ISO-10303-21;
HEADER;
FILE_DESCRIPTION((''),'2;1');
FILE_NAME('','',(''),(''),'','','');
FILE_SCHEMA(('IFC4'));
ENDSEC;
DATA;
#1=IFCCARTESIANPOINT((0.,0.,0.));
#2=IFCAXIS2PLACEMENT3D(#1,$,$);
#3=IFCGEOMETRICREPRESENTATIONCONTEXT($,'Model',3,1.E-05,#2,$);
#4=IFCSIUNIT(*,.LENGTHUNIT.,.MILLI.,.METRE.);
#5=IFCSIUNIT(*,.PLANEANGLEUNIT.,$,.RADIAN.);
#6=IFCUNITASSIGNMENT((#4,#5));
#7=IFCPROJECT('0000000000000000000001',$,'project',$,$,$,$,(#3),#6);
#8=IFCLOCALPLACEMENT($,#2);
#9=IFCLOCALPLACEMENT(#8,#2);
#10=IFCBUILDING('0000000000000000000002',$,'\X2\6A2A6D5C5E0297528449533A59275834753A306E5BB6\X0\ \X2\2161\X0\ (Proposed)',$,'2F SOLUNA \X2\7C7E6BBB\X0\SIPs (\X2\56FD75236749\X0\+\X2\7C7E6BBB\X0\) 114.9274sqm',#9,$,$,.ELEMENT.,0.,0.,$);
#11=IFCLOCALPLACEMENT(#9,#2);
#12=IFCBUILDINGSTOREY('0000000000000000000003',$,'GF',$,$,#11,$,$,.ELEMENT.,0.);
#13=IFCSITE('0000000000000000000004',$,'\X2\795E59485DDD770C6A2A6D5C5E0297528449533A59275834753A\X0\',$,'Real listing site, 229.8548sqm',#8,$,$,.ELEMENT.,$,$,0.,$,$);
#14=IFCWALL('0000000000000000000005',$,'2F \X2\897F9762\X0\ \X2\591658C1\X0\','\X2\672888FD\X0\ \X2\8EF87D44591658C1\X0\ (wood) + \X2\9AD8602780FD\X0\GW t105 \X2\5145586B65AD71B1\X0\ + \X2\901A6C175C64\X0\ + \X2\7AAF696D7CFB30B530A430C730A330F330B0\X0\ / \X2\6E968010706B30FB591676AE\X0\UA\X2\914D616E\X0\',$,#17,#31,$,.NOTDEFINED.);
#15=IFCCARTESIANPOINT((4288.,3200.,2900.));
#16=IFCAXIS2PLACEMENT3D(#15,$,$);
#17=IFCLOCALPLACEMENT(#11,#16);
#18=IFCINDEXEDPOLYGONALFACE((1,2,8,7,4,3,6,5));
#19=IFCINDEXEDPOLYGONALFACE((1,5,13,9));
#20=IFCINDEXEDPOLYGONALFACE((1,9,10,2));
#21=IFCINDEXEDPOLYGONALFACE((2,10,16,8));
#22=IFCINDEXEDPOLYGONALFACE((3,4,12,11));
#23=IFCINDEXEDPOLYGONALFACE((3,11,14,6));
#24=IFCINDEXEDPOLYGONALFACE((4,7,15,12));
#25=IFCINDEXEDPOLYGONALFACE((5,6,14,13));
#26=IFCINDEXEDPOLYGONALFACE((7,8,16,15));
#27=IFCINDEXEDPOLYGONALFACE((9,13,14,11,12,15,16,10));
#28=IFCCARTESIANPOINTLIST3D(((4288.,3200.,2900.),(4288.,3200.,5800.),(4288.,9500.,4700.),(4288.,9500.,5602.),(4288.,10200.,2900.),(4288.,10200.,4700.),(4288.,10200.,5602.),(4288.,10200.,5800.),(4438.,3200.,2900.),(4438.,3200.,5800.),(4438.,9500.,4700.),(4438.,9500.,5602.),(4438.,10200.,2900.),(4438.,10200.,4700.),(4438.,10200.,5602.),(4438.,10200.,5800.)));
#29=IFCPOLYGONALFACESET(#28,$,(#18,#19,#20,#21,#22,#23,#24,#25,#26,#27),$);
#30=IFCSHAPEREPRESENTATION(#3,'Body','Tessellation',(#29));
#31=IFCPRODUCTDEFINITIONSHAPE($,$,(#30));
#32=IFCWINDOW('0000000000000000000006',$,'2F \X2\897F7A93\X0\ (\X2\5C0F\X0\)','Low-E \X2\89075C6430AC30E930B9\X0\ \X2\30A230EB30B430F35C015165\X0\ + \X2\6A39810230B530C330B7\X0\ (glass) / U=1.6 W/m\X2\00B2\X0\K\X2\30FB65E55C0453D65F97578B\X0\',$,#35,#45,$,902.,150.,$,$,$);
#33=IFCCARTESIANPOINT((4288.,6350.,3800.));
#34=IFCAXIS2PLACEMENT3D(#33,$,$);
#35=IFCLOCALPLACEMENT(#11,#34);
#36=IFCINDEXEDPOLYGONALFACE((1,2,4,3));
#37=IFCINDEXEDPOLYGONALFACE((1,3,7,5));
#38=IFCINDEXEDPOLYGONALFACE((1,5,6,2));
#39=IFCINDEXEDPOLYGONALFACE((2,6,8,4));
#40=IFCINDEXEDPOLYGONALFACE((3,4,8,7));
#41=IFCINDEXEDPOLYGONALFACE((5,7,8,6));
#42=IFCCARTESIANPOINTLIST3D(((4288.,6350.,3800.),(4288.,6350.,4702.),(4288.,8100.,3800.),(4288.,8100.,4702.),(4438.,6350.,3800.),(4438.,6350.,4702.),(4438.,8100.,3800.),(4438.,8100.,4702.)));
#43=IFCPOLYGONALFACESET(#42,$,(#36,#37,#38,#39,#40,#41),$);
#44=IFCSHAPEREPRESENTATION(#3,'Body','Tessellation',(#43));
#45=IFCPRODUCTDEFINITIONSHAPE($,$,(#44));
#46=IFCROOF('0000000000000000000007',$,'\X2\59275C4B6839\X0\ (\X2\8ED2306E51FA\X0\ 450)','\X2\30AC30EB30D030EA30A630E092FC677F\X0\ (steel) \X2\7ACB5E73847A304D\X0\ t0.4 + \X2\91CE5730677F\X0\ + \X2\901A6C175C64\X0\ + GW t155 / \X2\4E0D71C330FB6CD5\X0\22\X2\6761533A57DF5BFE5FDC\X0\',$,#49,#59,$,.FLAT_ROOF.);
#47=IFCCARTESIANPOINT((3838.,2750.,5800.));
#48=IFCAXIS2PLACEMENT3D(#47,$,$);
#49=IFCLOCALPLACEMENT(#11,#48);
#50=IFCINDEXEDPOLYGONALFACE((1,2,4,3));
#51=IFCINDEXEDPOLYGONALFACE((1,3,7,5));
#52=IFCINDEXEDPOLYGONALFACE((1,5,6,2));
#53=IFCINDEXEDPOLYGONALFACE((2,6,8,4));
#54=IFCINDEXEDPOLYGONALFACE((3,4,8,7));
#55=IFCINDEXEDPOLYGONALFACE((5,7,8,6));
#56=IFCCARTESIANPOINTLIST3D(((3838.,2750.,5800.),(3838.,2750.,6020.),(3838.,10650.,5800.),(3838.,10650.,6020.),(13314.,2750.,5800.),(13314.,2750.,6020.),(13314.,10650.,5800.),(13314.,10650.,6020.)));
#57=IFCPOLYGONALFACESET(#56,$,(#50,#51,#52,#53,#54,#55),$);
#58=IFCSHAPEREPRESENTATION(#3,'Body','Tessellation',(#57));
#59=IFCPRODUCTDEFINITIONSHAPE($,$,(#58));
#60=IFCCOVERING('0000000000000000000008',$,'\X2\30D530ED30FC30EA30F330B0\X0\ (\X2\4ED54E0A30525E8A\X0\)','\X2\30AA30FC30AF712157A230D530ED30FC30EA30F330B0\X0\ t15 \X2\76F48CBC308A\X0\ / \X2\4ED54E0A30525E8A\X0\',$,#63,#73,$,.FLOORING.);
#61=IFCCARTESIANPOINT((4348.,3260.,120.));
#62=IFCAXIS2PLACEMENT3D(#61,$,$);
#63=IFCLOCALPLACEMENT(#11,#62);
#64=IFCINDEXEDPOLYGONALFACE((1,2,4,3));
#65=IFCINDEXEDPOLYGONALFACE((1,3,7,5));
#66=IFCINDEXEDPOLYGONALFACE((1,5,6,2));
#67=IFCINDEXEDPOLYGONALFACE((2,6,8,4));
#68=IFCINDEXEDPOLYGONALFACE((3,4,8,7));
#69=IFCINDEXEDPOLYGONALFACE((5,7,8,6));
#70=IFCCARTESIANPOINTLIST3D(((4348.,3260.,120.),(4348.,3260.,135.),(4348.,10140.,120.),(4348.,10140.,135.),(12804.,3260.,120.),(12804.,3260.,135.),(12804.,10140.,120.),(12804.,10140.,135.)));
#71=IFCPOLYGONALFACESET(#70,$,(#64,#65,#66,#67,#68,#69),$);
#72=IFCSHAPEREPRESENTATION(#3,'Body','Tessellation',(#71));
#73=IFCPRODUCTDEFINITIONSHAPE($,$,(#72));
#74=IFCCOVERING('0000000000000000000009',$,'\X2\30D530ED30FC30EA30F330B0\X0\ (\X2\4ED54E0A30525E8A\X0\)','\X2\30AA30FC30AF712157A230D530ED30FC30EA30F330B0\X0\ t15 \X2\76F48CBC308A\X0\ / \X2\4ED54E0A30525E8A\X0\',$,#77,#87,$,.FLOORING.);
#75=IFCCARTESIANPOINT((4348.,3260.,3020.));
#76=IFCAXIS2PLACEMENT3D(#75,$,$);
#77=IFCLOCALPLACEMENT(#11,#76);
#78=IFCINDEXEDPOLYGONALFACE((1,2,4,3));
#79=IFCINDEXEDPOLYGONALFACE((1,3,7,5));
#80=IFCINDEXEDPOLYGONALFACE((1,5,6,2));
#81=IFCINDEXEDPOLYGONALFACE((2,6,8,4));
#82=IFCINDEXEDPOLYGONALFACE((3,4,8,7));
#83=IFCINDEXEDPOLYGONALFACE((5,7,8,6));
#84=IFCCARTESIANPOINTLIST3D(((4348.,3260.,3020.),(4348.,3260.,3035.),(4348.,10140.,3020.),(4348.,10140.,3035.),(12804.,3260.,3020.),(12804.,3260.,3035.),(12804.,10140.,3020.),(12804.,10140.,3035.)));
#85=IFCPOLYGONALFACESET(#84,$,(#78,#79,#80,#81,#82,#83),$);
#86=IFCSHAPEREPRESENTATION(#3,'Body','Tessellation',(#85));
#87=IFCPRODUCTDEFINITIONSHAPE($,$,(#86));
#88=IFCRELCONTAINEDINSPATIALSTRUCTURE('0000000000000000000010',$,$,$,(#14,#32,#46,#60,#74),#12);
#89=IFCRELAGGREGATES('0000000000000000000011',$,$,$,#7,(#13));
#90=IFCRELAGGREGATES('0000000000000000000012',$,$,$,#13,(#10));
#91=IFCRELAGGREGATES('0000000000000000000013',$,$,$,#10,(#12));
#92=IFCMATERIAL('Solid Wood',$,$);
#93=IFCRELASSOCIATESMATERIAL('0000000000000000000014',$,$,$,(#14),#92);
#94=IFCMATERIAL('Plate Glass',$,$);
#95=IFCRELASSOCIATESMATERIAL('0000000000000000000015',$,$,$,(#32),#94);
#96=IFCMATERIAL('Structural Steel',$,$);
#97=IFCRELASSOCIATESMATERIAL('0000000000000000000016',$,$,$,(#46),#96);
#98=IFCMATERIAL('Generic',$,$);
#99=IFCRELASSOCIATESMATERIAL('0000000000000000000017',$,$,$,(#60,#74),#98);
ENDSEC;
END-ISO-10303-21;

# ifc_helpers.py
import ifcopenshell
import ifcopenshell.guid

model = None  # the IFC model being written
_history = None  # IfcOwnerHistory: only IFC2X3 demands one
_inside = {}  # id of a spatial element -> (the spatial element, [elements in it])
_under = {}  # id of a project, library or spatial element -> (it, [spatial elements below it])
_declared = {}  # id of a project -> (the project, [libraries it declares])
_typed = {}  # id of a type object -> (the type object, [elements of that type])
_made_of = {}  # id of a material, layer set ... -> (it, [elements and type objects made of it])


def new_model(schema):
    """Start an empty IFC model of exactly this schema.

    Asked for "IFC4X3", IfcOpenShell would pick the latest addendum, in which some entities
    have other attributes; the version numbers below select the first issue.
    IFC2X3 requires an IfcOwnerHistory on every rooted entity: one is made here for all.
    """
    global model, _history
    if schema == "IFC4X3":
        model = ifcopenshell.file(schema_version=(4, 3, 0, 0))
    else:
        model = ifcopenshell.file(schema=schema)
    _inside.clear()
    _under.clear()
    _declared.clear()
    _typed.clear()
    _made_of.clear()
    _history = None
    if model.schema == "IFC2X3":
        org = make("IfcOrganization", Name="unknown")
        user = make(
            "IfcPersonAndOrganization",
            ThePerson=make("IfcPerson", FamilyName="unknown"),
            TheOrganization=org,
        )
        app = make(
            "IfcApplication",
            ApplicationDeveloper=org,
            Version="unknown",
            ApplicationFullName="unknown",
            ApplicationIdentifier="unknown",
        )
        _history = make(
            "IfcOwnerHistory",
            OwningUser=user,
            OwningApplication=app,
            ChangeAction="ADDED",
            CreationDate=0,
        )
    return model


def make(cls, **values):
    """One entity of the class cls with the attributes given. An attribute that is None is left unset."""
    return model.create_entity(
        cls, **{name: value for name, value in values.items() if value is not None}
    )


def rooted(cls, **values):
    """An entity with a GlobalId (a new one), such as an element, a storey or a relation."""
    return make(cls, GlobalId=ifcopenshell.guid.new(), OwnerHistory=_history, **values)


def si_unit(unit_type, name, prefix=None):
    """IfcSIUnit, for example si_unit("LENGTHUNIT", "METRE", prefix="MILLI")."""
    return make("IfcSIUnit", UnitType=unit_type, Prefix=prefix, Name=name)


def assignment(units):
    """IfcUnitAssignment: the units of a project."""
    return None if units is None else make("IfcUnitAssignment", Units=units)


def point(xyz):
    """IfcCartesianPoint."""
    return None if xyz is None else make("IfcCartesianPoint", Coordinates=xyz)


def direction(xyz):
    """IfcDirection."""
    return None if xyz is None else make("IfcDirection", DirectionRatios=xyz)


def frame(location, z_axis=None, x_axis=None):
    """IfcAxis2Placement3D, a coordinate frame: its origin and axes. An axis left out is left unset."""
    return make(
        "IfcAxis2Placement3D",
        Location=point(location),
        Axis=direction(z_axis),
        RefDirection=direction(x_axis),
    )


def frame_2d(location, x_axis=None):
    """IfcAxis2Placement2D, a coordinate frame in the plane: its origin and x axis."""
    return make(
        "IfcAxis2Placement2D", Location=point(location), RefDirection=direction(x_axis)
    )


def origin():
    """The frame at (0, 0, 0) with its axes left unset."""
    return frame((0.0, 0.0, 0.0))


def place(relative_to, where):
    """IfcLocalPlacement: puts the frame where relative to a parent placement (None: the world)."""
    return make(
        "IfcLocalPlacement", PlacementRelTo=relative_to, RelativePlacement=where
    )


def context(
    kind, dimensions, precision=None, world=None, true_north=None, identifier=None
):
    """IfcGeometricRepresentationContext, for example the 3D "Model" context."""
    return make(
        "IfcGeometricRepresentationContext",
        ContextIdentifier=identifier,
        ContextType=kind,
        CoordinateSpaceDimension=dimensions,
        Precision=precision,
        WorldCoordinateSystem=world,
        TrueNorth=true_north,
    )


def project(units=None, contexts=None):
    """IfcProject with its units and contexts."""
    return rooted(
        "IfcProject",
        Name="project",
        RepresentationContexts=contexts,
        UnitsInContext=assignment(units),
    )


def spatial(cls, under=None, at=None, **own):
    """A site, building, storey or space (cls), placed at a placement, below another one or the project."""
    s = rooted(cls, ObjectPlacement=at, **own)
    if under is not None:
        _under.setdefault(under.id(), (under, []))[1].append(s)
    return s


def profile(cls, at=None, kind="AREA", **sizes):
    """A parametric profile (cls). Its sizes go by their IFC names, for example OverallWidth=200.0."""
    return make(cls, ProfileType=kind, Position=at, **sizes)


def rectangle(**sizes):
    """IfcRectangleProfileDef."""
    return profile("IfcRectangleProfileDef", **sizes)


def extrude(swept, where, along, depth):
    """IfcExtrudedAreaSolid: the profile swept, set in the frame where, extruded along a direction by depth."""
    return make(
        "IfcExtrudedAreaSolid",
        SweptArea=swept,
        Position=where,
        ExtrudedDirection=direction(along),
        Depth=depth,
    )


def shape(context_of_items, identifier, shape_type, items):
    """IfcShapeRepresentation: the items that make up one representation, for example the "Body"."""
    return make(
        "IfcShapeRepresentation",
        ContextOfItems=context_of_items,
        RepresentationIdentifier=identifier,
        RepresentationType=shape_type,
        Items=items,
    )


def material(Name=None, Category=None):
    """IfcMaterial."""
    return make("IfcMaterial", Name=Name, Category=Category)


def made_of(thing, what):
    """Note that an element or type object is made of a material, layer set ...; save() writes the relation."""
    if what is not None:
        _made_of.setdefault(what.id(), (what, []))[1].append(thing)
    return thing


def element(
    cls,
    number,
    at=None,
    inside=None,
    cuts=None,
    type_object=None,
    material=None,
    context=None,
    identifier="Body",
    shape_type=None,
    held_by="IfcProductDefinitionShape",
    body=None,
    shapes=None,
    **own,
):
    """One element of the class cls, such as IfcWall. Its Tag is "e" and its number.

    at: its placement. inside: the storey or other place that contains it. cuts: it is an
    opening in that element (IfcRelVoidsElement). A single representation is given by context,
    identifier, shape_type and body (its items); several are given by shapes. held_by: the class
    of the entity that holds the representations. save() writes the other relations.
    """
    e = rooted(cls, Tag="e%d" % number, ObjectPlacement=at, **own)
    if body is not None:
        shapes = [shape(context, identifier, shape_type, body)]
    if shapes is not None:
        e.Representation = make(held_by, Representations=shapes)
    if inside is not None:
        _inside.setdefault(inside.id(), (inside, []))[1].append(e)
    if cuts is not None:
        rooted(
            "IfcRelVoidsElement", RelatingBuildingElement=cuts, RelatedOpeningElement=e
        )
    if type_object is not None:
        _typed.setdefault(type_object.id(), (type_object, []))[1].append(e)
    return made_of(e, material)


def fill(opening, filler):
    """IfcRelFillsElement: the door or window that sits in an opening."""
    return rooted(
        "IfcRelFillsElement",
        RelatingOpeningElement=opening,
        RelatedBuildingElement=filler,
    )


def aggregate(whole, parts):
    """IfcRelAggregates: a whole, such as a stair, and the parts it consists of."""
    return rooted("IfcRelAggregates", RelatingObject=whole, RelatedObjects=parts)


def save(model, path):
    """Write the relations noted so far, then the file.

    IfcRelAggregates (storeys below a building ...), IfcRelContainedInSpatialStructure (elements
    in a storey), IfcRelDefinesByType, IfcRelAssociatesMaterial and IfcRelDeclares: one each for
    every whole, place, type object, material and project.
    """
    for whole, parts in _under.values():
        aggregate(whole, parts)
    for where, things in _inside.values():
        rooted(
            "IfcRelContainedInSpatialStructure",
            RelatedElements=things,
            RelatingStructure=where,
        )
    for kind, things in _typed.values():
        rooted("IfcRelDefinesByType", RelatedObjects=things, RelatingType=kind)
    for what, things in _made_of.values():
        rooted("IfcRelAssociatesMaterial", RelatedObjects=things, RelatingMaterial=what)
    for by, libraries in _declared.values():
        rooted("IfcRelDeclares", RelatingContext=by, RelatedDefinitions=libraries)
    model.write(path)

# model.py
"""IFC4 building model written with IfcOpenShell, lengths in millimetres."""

from ifc_helpers import new_model, si_unit, frame, frame_2d, origin, place, context, project, spatial, rectangle, extrude, material, element, fill, save


model = new_model("IFC4")

# Units and contexts
model_context = context("Model", 3, precision=1e-05, world=origin())
ifc_project = project(units=[si_unit("LENGTHUNIT", "METRE", prefix="MILLI"), si_unit("PLANEANGLEUNIT", "RADIAN")], contexts=[model_context])

# Site, building, storey
site_placement = place(None, origin())
site = spatial("IfcSite", under=ifc_project, at=site_placement, Name="神奈川県横浜市青葉区大場町", ObjectType="Real listing site, 229.8548sqm", CompositionType="ELEMENT", RefElevation=0.0)
building_placement = place(site_placement, origin())
building = spatial("IfcBuilding", under=site, at=building_placement, Name="横浜市青葉区大場町の家 Ⅱ (Proposed)", ObjectType="2F SOLUNA 籾殻SIPs (国産杉+籾殻) 114.9274sqm", CompositionType="ELEMENT", ElevationOfRefHeight=0.0, ElevationOfTerrain=0.0)
storey_placement = place(building_placement, origin())
storey = spatial("IfcBuildingStorey", under=building, at=storey_placement, Name="GF", CompositionType="ELEMENT", Elevation=0.0)

# Shared definitions
ifc_material_1 = material(Name="Solid Wood")

# Shared definitions
ifc_material_2 = material(Name="Plate Glass")

# Wall, opening, window
wall_1_placement = place(storey_placement, frame((4288.0, 3200.0, 2900.0)))
wall_1 = element("IfcWall", 1, at=wall_1_placement, inside=storey, material=ifc_material_1, Name="2F 西面 外壁", Description="木製 軸組外壁 (wood) + 高性能GW t105 充填断熱 + 通気層 + 窯業系サイディング / 準耐火・外皮UA配慮", PredefinedType="NOTDEFINED", context=model_context, shape_type="SweptSolid", body=[
    extrude(rectangle(XDim=150.0, YDim=7000.0, at=frame_2d((75.0, 3500.0))), frame((4288.0, 3200.0, 2900.0)), (0.0, 0.0, 1.0), 2900.0),
])
opening_1_placement = place(storey_placement, frame((4288.0, 6350.0, 3800.0)))
opening_1 = element("IfcOpeningElement", 2, at=opening_1_placement, cuts=wall_1, PredefinedType="NOTDEFINED", context=model_context, shape_type="SweptSolid", body=[
    extrude(rectangle(XDim=150.0, YDim=1750.0, at=frame_2d((75.0, 875.0))), frame((4288.0, 6350.0, 3800.0)), (0.0, 0.0, 1.0), 902.0),
])
window_1_placement = place(storey_placement, frame((4288.0, 6350.0, 3800.0)))
window_1 = element("IfcWindow", 3, at=window_1_placement, inside=storey, material=ifc_material_2, Name="2F 西窓 (小)", Description="Low-E 複層ガラス アルゴン封入 + 樹脂サッシ (glass) / U=1.6 W/m²K・日射取得型", OverallHeight=902.0, OverallWidth=150.0, context=model_context, shape_type="SweptSolid", body=[
    extrude(rectangle(XDim=150.0, YDim=1750.0, at=frame_2d((75.0, 875.0))), frame((4288.0, 6350.0, 3800.0)), (0.0, 0.0, 1.0), 902.0),
])
fill(opening_1, window_1)

# Roof
ifc_material_3 = material(Name="Structural Steel")
roof_placement = place(storey_placement, frame((3838.0, 2750.0, 5800.0)))
element("IfcRoof", 4, at=roof_placement, inside=storey, material=ifc_material_3, Name="大屋根 (軒の出 450)", Description="ガルバリウム鋼板 (steel) 立平葺き t0.4 + 野地板 + 通気層 + GW t155 / 不燃・法22条区域対応", PredefinedType="FLAT_ROOF", context=model_context, shape_type="SweptSolid", body=[
    extrude(rectangle(XDim=9476.0, YDim=7900.0, at=frame_2d((4738.0, 3950.0))), frame((3838.0, 2750.0, 5800.0)), (0.0, 0.0, 1.0), 220.0),
])

# Coverings
ifc_material_4 = material(Name="Generic")
covering_1_placement = place(storey_placement, frame((4348.0, 3260.0, 120.0)))
element("IfcCovering", 5, at=covering_1_placement, inside=storey, material=ifc_material_4, Name="フローリング (仕上げ床)", Description="オーク無垢フローリング t15 直貼り / 仕上げ床", PredefinedType="FLOORING", context=model_context, shape_type="SweptSolid", body=[
    extrude(rectangle(XDim=8456.0, YDim=6880.0, at=frame_2d((4228.0, 3440.0))), frame((4348.0, 3260.0, 120.0)), (0.0, 0.0, 1.0), 15.0),
])
covering_2_placement = place(storey_placement, frame((4348.0, 3260.0, 3020.0)))
element("IfcCovering", 6, at=covering_2_placement, inside=storey, material=ifc_material_4, Name="フローリング (仕上げ床)", Description="オーク無垢フローリング t15 直貼り / 仕上げ床", PredefinedType="FLOORING", context=model_context, shape_type="SweptSolid", body=[
    extrude(rectangle(XDim=8456.0, YDim=6880.0, at=frame_2d((4228.0, 3440.0))), frame((4348.0, 3260.0, 3020.0)), (0.0, 0.0, 1.0), 15.0),
])

save(model, "model.ifc")
